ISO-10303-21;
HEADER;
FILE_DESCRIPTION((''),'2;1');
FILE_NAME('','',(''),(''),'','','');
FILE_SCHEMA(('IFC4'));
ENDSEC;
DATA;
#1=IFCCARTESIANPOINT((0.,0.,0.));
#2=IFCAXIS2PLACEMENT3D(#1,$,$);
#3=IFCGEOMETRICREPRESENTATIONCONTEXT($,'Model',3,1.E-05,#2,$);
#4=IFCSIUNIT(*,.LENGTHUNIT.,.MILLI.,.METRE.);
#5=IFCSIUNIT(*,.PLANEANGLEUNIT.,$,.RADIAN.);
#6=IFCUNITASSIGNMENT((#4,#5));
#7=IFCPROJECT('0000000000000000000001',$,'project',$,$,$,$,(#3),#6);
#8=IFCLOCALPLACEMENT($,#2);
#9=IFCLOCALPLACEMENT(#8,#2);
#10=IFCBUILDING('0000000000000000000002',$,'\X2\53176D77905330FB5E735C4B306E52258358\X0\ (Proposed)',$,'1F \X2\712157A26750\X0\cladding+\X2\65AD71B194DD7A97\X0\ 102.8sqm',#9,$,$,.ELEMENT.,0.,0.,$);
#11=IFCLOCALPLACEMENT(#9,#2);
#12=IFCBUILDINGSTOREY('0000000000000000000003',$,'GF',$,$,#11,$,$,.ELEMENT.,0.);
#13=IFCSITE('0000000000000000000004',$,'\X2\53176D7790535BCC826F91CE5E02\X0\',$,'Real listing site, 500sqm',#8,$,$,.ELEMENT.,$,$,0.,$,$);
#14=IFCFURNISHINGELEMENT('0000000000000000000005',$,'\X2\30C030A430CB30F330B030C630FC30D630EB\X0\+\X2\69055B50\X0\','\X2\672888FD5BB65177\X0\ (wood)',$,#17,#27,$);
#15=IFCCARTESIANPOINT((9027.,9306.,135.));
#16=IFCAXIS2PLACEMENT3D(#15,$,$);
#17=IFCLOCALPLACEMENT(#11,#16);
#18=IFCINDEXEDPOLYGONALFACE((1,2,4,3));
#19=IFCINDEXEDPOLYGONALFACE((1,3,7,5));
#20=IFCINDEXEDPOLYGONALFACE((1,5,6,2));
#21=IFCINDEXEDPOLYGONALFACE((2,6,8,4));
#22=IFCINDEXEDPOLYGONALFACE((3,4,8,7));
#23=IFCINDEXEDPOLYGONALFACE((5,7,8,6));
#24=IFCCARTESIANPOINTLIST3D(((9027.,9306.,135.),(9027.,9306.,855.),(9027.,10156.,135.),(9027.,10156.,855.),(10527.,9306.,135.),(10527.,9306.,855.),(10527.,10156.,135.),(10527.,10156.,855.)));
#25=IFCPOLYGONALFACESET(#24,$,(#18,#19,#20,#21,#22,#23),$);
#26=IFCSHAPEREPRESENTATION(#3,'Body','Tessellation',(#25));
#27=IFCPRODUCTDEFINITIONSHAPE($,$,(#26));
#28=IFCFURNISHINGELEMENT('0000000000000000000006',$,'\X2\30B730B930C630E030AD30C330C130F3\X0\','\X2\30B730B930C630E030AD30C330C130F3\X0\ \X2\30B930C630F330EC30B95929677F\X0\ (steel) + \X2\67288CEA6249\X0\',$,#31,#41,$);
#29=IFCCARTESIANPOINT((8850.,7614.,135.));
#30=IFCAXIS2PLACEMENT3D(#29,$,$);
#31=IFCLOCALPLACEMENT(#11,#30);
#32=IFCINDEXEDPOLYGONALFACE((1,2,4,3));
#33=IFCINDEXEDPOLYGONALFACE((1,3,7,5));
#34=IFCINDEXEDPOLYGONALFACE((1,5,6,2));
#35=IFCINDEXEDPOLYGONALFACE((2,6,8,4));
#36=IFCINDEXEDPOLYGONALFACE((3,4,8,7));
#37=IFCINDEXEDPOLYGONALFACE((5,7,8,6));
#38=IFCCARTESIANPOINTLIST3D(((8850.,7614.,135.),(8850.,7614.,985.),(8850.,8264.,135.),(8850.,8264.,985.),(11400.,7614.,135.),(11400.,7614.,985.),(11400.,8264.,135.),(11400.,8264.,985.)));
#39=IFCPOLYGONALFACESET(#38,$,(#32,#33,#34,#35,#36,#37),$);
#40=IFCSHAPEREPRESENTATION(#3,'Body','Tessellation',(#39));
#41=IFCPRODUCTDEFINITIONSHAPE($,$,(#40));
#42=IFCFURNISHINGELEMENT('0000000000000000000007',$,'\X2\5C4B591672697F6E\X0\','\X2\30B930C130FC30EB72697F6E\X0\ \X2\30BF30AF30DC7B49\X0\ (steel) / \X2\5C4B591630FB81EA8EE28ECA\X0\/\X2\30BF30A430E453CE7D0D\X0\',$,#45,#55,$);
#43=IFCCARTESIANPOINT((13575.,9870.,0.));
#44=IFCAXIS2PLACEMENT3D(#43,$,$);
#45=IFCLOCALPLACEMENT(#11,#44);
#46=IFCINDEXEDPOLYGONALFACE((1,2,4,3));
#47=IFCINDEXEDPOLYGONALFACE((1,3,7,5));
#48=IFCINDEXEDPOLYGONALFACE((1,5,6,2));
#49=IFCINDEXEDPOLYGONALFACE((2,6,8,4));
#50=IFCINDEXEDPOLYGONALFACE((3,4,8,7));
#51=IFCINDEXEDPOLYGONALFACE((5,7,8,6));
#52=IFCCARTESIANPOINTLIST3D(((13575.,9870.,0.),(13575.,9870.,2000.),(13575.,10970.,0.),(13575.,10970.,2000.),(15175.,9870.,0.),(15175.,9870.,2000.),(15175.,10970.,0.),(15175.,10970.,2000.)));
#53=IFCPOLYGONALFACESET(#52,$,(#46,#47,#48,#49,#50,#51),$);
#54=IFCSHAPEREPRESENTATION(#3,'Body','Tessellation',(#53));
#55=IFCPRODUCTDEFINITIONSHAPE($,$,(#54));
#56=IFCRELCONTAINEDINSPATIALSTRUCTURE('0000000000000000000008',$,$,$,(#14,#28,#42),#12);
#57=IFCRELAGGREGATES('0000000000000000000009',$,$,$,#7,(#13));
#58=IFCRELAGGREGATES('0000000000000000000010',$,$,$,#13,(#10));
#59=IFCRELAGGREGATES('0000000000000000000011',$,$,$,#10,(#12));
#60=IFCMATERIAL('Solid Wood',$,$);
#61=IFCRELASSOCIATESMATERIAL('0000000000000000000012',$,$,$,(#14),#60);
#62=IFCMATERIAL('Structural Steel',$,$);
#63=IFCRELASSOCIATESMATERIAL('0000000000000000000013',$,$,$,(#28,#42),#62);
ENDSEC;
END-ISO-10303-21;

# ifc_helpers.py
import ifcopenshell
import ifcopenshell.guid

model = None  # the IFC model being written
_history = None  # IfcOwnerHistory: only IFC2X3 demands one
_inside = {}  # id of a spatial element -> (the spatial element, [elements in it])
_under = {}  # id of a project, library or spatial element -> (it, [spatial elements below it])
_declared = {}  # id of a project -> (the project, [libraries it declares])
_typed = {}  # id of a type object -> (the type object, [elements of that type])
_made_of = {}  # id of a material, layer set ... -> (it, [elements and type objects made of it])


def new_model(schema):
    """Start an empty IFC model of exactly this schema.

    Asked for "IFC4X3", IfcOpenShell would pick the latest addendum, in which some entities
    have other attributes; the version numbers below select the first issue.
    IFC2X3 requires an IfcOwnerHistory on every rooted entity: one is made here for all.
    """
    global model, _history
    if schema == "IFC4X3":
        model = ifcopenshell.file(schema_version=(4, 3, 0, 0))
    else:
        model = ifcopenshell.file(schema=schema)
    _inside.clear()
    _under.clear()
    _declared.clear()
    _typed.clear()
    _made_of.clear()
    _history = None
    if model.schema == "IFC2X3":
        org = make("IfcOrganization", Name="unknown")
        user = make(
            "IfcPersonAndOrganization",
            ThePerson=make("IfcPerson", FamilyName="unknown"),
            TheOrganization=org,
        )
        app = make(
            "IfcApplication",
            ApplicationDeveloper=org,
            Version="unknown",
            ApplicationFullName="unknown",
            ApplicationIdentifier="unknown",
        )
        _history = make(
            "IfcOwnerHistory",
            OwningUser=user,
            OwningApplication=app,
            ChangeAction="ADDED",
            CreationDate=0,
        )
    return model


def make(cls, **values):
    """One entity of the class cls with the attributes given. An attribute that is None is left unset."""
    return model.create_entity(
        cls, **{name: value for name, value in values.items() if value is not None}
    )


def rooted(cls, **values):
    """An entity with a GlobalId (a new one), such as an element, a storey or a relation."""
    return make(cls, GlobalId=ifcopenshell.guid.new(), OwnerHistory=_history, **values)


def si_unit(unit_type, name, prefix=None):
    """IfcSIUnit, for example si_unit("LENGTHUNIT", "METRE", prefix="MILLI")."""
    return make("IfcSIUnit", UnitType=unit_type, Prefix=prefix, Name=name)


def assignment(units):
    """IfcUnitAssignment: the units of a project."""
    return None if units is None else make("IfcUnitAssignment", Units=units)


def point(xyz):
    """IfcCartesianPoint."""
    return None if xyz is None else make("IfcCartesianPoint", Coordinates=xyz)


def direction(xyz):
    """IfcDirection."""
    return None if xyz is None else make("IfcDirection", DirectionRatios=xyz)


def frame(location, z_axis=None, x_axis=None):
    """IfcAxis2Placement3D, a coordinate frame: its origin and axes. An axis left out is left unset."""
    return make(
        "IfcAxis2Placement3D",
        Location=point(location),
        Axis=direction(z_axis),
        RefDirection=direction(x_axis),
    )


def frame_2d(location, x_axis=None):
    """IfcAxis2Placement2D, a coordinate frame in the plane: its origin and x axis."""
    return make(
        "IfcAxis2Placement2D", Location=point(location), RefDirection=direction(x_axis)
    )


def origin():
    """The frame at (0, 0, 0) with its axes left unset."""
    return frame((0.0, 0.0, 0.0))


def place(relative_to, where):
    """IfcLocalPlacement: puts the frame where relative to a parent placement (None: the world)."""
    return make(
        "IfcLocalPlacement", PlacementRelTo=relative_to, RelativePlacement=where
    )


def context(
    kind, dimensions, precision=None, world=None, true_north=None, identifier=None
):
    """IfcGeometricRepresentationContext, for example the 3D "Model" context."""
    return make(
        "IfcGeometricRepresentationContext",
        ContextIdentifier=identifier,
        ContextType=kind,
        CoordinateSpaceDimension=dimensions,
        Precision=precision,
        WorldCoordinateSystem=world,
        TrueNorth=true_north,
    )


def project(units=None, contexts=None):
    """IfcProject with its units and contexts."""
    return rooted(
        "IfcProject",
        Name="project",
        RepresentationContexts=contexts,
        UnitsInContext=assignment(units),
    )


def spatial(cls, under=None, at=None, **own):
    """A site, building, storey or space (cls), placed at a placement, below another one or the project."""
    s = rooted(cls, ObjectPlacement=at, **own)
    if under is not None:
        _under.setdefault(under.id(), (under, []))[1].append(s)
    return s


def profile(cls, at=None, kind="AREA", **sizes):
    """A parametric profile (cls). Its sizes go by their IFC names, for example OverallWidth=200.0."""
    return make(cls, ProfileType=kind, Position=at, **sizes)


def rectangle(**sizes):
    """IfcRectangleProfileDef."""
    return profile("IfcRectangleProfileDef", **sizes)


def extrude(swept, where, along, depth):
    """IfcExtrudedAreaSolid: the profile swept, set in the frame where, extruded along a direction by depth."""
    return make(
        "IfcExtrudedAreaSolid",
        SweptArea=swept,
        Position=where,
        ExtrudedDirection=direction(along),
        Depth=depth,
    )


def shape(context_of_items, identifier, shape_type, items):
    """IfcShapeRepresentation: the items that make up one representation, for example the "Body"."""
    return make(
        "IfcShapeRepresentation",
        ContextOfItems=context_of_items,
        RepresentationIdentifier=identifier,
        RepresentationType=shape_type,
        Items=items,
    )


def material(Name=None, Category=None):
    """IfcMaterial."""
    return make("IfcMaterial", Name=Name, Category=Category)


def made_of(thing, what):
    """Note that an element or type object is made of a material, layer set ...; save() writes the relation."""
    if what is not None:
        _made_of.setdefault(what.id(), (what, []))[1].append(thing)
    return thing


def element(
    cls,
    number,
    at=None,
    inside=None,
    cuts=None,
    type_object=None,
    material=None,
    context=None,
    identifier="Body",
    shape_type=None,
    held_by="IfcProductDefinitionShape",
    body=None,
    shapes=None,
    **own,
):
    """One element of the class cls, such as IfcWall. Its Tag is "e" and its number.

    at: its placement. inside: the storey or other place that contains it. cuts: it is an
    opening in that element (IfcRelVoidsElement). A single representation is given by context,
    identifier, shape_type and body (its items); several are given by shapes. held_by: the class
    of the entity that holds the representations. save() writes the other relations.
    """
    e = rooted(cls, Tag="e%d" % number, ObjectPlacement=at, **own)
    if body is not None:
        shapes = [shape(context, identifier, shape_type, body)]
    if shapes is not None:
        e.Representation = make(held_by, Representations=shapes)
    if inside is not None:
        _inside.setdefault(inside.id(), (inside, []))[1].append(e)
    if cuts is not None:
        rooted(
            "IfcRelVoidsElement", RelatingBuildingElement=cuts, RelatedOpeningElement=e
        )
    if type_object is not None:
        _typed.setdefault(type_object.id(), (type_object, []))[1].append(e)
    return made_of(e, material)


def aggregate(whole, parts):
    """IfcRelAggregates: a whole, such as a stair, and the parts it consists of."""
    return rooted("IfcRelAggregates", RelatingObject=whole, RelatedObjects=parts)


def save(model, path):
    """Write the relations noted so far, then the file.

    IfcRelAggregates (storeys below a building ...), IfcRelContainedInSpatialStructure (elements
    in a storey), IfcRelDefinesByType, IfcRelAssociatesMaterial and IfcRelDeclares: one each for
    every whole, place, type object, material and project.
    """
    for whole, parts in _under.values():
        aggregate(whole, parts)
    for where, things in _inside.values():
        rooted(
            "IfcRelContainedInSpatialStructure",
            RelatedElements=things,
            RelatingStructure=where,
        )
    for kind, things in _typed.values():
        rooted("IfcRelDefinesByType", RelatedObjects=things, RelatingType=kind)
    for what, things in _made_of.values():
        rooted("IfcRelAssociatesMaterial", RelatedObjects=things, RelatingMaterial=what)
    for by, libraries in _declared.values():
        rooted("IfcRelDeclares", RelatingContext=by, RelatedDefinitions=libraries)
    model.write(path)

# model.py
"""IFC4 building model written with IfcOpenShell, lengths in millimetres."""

from ifc_helpers import new_model, si_unit, frame, frame_2d, origin, place, context, project, spatial, rectangle, extrude, material, element, save


model = new_model("IFC4")

# Units and contexts
model_context = context("Model", 3, precision=1e-05, world=origin())
ifc_project = project(units=[si_unit("LENGTHUNIT", "METRE", prefix="MILLI"), si_unit("PLANEANGLEUNIT", "RADIAN")], contexts=[model_context])

# Site, building, storey
site_placement = place(None, origin())
site = spatial("IfcSite", under=ifc_project, at=site_placement, Name="北海道富良野市", ObjectType="Real listing site, 500sqm", CompositionType="ELEMENT", RefElevation=0.0)
building_placement = place(site_placement, origin())
building = spatial("IfcBuilding", under=site, at=building_placement, Name="北海道・平屋の別荘 (Proposed)", ObjectType="1F 無垢材cladding+断熱铝窗 102.8sqm", CompositionType="ELEMENT", ElevationOfRefHeight=0.0, ElevationOfTerrain=0.0)
storey_placement = place(building_placement, origin())
storey = spatial("IfcBuildingStorey", under=building, at=storey_placement, Name="GF", CompositionType="ELEMENT", Elevation=0.0)

# Shared definitions
ifc_material_1 = material(Name="Solid Wood")

# Shared definitions
ifc_material_2 = material(Name="Structural Steel")

# Furnishing elements
furnishing_1_placement = place(storey_placement, frame((9027.0, 9306.0, 135.0)))
element("IfcFurnishingElement", 1, at=furnishing_1_placement, inside=storey, material=ifc_material_1, Name="ダイニングテーブル+椅子", Description="木製家具 (wood)", context=model_context, shape_type="SweptSolid", body=[
    extrude(rectangle(XDim=1500.0, YDim=850.0, at=frame_2d((750.0, 425.0))), frame((9027.0, 9306.0, 135.0)), (0.0, 0.0, 1.0), 720.0),
])
furnishing_2_placement = place(storey_placement, frame((8850.0, 7614.0, 135.0)))
element("IfcFurnishingElement", 2, at=furnishing_2_placement, inside=storey, material=ifc_material_2, Name="システムキッチン", Description="システムキッチン ステンレス天板 (steel) + 木質扉", context=model_context, shape_type="SweptSolid", body=[
    extrude(rectangle(XDim=2550.0, YDim=650.0, at=frame_2d((1275.0, 325.0))), frame((8850.0, 7614.0, 135.0)), (0.0, 0.0, 1.0), 850.0),
])
furnishing_3_placement = place(storey_placement, frame((13575.0, 9870.0, 0.0)))
element("IfcFurnishingElement", 3, at=furnishing_3_placement, inside=storey, material=ifc_material_2, Name="屋外物置", Description="スチール物置 タクボ等 (steel) / 屋外・自転車/タイヤ収納", context=model_context, shape_type="SweptSolid", body=[
    extrude(rectangle(XDim=1600.0, YDim=1100.0, at=frame_2d((800.0, 550.0))), frame((13575.0, 9870.0, 0.0)), (0.0, 0.0, 1.0), 2000.0),
])

save(model, "model.ifc")
